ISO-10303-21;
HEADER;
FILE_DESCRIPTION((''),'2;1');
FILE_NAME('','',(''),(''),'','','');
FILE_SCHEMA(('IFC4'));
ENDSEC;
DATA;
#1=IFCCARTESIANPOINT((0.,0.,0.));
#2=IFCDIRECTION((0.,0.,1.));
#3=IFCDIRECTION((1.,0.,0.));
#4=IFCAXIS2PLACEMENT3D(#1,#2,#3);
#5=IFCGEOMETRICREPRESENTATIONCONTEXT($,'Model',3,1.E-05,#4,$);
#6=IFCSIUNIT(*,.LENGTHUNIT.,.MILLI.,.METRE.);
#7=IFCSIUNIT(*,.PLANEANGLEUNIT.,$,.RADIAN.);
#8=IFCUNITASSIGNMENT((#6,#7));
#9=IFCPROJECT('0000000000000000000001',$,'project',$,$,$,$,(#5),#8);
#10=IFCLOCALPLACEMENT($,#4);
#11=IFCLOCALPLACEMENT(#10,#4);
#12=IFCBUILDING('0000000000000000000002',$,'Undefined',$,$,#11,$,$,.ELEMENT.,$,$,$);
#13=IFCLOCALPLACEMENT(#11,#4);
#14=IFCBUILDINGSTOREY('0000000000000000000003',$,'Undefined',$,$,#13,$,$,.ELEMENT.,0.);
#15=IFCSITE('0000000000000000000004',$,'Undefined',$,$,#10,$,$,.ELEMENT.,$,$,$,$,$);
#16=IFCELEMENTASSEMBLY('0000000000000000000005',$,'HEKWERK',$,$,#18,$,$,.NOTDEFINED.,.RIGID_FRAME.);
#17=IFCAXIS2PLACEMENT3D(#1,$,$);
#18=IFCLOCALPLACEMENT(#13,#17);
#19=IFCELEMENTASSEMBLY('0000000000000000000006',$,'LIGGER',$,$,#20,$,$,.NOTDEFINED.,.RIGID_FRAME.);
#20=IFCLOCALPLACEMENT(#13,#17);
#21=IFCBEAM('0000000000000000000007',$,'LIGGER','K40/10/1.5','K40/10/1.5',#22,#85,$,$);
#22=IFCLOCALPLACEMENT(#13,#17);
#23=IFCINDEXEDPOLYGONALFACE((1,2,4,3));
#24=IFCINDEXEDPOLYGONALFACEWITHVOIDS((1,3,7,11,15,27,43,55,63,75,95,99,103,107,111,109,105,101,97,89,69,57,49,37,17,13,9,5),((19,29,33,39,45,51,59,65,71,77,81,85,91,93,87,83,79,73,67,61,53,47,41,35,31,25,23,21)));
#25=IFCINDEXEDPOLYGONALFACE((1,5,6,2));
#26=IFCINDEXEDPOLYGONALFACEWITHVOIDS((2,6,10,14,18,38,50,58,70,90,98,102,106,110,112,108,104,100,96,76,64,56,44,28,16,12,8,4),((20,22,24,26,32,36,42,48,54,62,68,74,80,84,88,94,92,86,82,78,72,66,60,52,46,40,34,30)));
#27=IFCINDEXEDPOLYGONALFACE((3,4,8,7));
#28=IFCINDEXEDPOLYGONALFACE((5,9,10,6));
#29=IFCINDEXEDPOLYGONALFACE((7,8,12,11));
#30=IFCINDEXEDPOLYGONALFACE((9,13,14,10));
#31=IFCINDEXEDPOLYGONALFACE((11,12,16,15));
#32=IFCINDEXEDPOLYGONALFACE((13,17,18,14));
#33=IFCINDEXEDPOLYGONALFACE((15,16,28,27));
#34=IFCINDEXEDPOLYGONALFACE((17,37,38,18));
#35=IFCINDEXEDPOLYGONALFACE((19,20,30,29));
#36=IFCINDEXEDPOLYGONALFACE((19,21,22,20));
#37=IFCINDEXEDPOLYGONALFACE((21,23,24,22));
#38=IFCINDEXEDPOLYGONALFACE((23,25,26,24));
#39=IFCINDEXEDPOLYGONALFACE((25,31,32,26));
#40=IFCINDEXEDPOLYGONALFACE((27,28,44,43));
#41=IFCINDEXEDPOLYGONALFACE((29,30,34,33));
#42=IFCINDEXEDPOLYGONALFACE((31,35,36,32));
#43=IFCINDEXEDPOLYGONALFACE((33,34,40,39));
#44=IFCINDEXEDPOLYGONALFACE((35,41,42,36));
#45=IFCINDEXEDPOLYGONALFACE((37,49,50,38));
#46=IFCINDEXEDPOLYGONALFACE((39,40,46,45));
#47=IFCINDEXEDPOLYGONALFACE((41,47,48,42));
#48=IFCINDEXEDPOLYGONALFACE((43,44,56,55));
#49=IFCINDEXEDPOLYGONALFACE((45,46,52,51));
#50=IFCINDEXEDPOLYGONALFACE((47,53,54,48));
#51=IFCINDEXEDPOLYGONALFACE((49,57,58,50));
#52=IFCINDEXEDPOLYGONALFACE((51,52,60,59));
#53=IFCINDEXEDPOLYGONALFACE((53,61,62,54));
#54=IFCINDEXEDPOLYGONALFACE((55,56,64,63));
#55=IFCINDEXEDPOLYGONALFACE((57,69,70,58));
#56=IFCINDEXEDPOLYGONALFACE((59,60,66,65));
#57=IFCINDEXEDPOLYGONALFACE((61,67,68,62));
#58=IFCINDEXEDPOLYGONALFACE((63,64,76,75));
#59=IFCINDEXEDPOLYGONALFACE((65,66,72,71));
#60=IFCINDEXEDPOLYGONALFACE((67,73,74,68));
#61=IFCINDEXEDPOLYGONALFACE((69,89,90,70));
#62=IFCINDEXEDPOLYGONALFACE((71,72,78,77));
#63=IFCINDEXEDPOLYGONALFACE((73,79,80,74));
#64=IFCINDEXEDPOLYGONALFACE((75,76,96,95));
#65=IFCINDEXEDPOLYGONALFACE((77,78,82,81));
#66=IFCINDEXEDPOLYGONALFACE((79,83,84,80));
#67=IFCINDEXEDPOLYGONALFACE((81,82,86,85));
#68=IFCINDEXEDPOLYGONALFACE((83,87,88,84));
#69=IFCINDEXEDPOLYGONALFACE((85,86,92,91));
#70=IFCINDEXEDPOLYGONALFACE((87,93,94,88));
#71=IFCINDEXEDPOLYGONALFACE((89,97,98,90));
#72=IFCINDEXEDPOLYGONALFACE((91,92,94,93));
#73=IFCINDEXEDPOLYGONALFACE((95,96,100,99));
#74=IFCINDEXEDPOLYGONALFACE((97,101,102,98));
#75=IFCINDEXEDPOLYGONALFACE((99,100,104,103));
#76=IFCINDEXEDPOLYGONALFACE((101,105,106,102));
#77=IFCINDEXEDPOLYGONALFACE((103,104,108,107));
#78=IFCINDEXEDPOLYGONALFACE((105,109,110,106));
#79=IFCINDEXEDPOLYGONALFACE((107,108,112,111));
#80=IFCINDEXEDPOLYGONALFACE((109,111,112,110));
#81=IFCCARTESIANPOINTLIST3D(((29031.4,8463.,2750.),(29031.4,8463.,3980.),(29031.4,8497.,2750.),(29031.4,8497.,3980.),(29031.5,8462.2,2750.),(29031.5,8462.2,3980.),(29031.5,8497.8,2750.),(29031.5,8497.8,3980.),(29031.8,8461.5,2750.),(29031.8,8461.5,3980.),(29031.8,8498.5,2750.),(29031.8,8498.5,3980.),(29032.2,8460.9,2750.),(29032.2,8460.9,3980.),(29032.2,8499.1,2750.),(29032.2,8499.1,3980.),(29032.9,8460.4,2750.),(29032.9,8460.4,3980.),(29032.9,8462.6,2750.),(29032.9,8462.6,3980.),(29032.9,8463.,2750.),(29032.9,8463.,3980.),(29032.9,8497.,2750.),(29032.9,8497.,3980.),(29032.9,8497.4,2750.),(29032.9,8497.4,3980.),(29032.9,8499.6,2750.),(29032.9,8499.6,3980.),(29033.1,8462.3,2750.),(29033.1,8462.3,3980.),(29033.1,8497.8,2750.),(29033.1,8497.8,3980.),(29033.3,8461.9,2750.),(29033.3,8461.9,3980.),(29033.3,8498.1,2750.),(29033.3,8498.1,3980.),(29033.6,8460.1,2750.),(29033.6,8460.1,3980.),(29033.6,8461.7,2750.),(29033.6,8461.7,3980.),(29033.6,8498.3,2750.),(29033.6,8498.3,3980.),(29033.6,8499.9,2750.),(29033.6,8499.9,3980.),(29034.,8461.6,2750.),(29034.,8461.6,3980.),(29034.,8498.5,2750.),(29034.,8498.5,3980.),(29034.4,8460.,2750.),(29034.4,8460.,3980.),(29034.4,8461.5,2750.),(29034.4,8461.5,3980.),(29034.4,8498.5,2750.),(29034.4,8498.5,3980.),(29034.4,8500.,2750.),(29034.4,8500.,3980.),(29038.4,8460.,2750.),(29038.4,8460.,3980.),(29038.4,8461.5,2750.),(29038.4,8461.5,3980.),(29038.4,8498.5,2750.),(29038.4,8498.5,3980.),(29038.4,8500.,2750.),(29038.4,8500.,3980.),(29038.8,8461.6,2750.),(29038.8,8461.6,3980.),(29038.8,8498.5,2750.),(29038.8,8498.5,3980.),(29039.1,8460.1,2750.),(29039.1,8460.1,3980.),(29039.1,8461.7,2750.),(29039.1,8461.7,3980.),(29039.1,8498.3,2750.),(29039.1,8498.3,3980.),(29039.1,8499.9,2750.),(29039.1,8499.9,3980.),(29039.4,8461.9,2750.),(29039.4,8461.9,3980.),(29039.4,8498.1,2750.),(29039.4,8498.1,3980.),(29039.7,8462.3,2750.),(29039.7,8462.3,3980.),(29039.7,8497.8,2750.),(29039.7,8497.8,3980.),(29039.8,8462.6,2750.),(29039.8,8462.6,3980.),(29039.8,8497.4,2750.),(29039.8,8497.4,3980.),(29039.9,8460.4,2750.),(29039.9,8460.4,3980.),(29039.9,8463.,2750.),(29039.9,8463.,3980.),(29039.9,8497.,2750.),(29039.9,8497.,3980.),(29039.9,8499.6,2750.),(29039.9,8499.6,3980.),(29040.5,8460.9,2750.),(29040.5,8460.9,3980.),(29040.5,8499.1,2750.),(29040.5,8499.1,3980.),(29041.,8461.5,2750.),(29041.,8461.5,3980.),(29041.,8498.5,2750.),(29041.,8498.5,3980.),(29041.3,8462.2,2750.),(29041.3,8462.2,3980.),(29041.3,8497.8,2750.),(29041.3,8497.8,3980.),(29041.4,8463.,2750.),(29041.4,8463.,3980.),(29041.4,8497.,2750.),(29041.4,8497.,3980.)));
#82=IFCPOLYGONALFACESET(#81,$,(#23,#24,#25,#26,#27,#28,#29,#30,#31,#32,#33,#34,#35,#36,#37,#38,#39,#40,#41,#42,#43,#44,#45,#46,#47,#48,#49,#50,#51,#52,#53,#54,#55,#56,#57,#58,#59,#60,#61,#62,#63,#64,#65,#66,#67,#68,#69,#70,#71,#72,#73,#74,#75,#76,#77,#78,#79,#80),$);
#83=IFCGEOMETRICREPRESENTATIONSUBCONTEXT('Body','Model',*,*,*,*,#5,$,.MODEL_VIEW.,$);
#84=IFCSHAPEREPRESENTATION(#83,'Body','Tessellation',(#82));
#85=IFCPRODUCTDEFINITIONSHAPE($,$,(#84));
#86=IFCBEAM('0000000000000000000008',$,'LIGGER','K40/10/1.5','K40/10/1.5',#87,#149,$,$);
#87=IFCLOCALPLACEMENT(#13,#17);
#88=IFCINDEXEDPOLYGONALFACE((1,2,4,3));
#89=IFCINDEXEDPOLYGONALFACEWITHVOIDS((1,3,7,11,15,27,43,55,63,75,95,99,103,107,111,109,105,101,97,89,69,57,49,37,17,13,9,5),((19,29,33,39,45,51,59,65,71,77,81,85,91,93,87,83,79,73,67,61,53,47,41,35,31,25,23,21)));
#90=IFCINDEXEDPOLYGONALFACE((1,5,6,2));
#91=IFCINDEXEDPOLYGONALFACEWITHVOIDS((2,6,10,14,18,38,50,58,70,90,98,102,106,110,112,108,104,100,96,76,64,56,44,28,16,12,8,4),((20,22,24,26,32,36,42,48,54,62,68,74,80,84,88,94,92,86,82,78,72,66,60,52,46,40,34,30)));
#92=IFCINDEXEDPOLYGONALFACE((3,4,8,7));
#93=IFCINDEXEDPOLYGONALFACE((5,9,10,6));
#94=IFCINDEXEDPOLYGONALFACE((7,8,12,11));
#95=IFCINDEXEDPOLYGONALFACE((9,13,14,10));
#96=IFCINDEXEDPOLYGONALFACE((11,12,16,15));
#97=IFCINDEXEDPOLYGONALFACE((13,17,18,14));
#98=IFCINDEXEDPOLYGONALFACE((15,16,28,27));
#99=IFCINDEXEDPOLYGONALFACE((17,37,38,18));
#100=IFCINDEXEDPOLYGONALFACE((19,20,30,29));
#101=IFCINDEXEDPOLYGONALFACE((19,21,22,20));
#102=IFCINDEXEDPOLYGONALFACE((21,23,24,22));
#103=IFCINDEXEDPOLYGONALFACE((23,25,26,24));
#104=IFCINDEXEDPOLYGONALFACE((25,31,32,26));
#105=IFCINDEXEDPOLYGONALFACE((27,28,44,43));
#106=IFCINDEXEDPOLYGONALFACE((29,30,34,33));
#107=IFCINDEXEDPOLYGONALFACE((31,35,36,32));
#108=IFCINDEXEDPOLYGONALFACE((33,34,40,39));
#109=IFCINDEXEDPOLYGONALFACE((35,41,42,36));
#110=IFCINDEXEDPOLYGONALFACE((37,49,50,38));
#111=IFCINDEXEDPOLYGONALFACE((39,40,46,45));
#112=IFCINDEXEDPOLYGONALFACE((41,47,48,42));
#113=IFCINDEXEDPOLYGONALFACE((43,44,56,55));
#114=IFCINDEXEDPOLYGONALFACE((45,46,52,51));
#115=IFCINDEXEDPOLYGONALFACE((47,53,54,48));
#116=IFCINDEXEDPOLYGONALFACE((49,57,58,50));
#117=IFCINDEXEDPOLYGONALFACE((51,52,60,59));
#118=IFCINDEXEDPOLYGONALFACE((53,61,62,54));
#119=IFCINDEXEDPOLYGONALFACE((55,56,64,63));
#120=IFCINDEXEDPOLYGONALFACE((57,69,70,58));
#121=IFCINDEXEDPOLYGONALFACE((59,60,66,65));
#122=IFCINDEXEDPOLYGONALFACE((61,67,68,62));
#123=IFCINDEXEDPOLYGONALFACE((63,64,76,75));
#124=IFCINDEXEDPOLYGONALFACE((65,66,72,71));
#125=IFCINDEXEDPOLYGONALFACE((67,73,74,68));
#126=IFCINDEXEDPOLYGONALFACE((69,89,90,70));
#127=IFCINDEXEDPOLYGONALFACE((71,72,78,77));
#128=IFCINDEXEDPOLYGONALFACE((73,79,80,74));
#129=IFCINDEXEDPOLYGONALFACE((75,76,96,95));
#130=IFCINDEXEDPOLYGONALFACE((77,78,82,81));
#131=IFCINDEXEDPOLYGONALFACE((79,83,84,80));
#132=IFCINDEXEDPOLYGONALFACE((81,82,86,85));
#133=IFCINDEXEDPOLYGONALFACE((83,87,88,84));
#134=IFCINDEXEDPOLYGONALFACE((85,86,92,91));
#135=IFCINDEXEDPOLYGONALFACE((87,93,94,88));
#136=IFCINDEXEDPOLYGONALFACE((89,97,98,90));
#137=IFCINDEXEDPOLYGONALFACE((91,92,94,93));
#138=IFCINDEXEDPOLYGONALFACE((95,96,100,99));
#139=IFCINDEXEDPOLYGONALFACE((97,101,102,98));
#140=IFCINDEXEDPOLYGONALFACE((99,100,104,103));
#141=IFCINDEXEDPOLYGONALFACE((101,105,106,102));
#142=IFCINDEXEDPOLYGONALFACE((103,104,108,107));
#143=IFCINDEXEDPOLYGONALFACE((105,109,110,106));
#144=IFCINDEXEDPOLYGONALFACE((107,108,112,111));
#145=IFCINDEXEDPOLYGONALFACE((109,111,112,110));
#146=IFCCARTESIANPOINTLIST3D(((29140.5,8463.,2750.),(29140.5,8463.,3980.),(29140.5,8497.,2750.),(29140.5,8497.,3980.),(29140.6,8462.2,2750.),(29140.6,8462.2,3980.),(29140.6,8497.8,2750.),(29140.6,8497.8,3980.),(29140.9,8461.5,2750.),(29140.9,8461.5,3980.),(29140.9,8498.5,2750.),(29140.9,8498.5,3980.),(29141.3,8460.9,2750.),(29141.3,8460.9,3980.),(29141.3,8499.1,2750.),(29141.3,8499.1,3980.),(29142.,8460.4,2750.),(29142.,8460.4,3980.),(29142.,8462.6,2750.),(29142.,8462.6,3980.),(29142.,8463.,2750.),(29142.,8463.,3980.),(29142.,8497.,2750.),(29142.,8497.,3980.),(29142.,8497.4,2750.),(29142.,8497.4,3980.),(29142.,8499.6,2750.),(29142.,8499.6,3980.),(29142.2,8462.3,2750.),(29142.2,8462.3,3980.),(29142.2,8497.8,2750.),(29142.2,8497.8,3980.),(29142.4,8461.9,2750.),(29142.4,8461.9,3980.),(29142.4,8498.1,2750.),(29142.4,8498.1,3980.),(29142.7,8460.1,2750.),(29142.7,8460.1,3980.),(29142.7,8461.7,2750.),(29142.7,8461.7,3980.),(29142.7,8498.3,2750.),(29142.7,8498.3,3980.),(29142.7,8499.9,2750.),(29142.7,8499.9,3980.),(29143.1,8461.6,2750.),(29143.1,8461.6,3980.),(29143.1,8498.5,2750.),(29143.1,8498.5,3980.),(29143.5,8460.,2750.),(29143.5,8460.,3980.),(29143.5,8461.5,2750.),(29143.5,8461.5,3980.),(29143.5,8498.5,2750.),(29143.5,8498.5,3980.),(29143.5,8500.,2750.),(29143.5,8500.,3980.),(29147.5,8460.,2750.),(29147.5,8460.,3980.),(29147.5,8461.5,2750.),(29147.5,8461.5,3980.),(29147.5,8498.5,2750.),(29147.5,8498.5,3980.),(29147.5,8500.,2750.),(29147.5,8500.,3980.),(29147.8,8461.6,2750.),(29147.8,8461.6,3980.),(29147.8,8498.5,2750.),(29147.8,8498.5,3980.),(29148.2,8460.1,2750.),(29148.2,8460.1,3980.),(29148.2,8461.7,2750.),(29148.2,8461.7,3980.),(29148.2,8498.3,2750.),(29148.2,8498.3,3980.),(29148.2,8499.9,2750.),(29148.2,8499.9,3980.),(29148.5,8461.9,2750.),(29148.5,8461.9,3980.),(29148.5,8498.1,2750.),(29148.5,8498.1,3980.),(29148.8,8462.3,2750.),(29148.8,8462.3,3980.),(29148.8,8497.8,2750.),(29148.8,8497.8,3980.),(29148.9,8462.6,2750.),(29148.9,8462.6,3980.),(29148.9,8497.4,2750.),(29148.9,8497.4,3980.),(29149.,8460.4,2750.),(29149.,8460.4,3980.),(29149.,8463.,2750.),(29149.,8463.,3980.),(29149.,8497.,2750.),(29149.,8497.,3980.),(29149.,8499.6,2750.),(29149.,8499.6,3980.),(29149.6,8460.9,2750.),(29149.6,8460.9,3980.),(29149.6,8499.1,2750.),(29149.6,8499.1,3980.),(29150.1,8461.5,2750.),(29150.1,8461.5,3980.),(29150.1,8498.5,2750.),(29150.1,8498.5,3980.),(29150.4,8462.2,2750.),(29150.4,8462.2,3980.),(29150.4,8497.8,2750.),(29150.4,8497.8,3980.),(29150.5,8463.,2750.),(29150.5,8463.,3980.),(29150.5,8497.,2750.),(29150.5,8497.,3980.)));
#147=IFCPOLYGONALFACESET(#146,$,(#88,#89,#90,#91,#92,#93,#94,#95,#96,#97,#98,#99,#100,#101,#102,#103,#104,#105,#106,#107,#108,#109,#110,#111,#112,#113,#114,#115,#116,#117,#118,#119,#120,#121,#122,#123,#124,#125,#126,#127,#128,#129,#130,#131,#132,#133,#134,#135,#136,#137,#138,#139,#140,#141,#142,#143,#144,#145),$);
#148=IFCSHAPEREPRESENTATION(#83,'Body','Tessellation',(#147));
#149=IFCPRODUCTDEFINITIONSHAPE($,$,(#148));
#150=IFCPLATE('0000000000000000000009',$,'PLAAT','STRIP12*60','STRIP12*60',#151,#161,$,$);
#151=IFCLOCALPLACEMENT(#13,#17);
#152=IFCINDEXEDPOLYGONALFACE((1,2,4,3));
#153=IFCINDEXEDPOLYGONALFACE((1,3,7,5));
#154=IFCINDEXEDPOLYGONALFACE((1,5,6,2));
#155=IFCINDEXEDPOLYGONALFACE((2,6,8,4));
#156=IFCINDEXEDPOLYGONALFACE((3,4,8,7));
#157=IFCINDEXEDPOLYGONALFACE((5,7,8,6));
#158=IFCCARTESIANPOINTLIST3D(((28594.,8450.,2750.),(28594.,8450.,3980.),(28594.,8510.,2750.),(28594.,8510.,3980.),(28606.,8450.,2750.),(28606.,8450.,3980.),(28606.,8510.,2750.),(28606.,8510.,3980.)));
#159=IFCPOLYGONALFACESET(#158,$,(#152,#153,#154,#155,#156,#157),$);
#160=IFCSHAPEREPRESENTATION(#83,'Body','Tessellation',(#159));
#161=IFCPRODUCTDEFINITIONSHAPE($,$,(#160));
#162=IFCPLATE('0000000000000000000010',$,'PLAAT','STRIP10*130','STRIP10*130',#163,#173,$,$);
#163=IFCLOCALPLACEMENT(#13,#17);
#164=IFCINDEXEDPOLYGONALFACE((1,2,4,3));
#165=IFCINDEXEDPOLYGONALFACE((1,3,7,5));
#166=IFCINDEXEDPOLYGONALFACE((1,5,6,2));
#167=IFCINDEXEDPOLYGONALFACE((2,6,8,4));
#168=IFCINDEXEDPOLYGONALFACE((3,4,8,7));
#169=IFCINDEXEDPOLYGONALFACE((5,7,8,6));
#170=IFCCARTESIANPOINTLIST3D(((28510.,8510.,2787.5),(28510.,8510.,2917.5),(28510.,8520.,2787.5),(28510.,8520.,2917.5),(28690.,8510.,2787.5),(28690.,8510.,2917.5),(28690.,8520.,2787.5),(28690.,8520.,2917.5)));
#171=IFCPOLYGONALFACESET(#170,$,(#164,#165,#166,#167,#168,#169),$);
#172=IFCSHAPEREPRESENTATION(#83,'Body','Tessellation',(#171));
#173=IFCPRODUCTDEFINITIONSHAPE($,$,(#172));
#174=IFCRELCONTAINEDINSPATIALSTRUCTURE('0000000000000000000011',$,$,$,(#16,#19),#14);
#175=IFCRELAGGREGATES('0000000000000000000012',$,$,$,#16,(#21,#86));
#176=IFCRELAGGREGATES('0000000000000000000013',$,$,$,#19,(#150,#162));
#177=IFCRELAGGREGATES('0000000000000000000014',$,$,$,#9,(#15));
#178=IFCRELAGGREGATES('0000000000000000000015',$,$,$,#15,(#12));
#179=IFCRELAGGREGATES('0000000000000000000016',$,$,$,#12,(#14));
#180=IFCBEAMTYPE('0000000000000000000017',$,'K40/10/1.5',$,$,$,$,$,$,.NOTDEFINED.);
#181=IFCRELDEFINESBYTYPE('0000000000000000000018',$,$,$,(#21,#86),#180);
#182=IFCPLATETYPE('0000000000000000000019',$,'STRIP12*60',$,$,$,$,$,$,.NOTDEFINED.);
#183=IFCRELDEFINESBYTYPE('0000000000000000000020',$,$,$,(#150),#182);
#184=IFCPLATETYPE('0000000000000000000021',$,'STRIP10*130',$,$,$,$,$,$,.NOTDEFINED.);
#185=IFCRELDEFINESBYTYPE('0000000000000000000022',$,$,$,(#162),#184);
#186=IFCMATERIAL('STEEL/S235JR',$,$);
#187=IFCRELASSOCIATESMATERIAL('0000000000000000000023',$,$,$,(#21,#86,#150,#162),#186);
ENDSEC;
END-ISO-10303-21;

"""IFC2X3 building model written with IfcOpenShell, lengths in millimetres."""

from ifc_helpers import new_model, si_unit, frame, origin_with_axes, origin_2d_with_axis, place, context, subcontext, project, spatial, rectangle, hollow_rectangle, extrude, clip, halfspace, material, type_object, element, aggregate, save


model = new_model("IFC2X3")

# Units and contexts
model_context = context("Model", 3, precision=1e-05, world=origin_with_axes())
body_context = subcontext(model_context, "Body", "Model", "MODEL_VIEW")
ifc_project = project(units=[si_unit("LENGTHUNIT", "METRE", prefix="MILLI"), si_unit("PLANEANGLEUNIT", "RADIAN")], contexts=[model_context])

# Site, building, storey
site_placement = place(None, origin_with_axes())
site = spatial("IfcSite", under=ifc_project, at=site_placement, Name="Undefined", CompositionType="ELEMENT")
building_placement = place(site_placement, origin_with_axes())
building = spatial("IfcBuilding", under=site, at=building_placement, Name="Undefined", CompositionType="ELEMENT")
storey_placement = place(building_placement, origin_with_axes())
storey = spatial("IfcBuildingStorey", under=building, at=storey_placement, Name="Undefined", CompositionType="ELEMENT", Elevation=0.0)

# Element assemblies
assembly_1_placement = place(storey_placement, origin_with_axes())
assembly_1 = element("IfcElementAssembly", 1, at=assembly_1_placement, inside=storey, Name="HEKWERK", AssemblyPlace="NOTDEFINED", PredefinedType="RIGID_FRAME")
ifc_material_1 = material(Name="STEEL/S235JR")
assembly_2_placement = place(storey_placement, origin_with_axes())
assembly_2 = element("IfcElementAssembly", 2, at=assembly_2_placement, inside=storey, Name="LIGGER", AssemblyPlace="NOTDEFINED", PredefinedType="RIGID_FRAME")
beam_type_1 = type_object("IfcBeamType", Name="K40/10/1.5", PredefinedType="NOTDEFINED")

# Beams
beam_1_placement = place(assembly_1_placement, frame((29036.4, 8480.0, 3980.0), z_axis=(0.0, 1.0, 0.0), x_axis=(0.0, 0.0, -1.0)))
beam_1 = element("IfcBeam", 3, at=beam_1_placement, type_object=beam_type_1, material=ifc_material_1, Name="LIGGER", Description="K40/10/1.5", ObjectType="K40/10/1.5", context=body_context, shape_type="Clipping", body=[
    clip(extrude(hollow_rectangle(XDim=10.0, YDim=40.0, WallThickness=1.5, InnerFilletRadius=1.5, OuterFilletRadius=3.0, at=origin_2d_with_axis()), frame((1230.0, 0.0, 0.0), z_axis=(-1.0, 0.0, 0.0), x_axis=(0.0, -1.0, 0.0)), (0.0, 0.0, 1.0), 1230.0), halfspace(frame((-7.0, -4.3, 47.4), z_axis=(-1.0, 0.0, 0.0), x_axis=(0.0, 0.768355, -0.640024)), False)),
])
beam_2_placement = place(assembly_1_placement, frame((29145.5, 8480.0, 3980.0), z_axis=(0.0, 1.0, 0.0), x_axis=(0.0, 0.0, -1.0)))
beam_2 = element("IfcBeam", 4, at=beam_2_placement, type_object=beam_type_1, material=ifc_material_1, Name="LIGGER", Description="K40/10/1.5", ObjectType="K40/10/1.5", context=body_context, shape_type="Clipping", body=[
    clip(extrude(hollow_rectangle(XDim=10.0, YDim=40.0, WallThickness=1.5, InnerFilletRadius=1.5, OuterFilletRadius=3.0, at=origin_2d_with_axis()), frame((1230.0, 0.0, 0.0), z_axis=(-1.0, 0.0, 0.0), x_axis=(0.0, -1.0, 0.0)), (0.0, 0.0, 1.0), 1230.0), halfspace(frame((-7.0, -4.3, 47.4), z_axis=(-1.0, 0.0, 0.0), x_axis=(0.0, 0.768355, -0.640024)), False)),
])

# Plates
plate_type_1 = type_object("IfcPlateType", Name="STRIP12*60", PredefinedType="NOTDEFINED")
plate_1_placement = place(assembly_2_placement, frame((28600.0, 8480.0, 3980.0), z_axis=(0.0, 1.0, 0.0), x_axis=(0.0, 0.0, -1.0)))
plate_1 = element("IfcPlate", 5, at=plate_1_placement, type_object=plate_type_1, material=ifc_material_1, Name="PLAAT", Description="STRIP12*60", ObjectType="STRIP12*60", context=body_context, shape_type="SweptSolid", body=[
    extrude(rectangle(XDim=12.0, YDim=60.0, at=origin_2d_with_axis()), frame((1230.0, 0.0, 0.0), z_axis=(-1.0, 0.0, 0.0), x_axis=(0.0, -1.0, 0.0)), (0.0, 0.0, 1.0), 1230.0),
])
plate_type_2 = type_object("IfcPlateType", Name="STRIP10*130", PredefinedType="NOTDEFINED")
plate_2_placement = place(assembly_2_placement, frame((28510.0, 8515.0, 2852.5), z_axis=(0.0, 0.0, 1.0), x_axis=(1.0, 0.0, 0.0)))
plate_2 = element("IfcPlate", 6, at=plate_2_placement, type_object=plate_type_2, material=ifc_material_1, Name="PLAAT", Description="STRIP10*130", ObjectType="STRIP10*130", context=body_context, shape_type="SweptSolid", body=[
    extrude(rectangle(XDim=10.0, YDim=130.0, at=origin_2d_with_axis()), frame((180.0, 0.0, 0.0), z_axis=(-1.0, 0.0, 0.0), x_axis=(0.0, -1.0, 0.0)), (0.0, 0.0, 1.0), 180.0),
])

aggregate(assembly_1, [beam_1, beam_2])
aggregate(assembly_2, [plate_1, plate_2])

save(model, "model.ifc")
